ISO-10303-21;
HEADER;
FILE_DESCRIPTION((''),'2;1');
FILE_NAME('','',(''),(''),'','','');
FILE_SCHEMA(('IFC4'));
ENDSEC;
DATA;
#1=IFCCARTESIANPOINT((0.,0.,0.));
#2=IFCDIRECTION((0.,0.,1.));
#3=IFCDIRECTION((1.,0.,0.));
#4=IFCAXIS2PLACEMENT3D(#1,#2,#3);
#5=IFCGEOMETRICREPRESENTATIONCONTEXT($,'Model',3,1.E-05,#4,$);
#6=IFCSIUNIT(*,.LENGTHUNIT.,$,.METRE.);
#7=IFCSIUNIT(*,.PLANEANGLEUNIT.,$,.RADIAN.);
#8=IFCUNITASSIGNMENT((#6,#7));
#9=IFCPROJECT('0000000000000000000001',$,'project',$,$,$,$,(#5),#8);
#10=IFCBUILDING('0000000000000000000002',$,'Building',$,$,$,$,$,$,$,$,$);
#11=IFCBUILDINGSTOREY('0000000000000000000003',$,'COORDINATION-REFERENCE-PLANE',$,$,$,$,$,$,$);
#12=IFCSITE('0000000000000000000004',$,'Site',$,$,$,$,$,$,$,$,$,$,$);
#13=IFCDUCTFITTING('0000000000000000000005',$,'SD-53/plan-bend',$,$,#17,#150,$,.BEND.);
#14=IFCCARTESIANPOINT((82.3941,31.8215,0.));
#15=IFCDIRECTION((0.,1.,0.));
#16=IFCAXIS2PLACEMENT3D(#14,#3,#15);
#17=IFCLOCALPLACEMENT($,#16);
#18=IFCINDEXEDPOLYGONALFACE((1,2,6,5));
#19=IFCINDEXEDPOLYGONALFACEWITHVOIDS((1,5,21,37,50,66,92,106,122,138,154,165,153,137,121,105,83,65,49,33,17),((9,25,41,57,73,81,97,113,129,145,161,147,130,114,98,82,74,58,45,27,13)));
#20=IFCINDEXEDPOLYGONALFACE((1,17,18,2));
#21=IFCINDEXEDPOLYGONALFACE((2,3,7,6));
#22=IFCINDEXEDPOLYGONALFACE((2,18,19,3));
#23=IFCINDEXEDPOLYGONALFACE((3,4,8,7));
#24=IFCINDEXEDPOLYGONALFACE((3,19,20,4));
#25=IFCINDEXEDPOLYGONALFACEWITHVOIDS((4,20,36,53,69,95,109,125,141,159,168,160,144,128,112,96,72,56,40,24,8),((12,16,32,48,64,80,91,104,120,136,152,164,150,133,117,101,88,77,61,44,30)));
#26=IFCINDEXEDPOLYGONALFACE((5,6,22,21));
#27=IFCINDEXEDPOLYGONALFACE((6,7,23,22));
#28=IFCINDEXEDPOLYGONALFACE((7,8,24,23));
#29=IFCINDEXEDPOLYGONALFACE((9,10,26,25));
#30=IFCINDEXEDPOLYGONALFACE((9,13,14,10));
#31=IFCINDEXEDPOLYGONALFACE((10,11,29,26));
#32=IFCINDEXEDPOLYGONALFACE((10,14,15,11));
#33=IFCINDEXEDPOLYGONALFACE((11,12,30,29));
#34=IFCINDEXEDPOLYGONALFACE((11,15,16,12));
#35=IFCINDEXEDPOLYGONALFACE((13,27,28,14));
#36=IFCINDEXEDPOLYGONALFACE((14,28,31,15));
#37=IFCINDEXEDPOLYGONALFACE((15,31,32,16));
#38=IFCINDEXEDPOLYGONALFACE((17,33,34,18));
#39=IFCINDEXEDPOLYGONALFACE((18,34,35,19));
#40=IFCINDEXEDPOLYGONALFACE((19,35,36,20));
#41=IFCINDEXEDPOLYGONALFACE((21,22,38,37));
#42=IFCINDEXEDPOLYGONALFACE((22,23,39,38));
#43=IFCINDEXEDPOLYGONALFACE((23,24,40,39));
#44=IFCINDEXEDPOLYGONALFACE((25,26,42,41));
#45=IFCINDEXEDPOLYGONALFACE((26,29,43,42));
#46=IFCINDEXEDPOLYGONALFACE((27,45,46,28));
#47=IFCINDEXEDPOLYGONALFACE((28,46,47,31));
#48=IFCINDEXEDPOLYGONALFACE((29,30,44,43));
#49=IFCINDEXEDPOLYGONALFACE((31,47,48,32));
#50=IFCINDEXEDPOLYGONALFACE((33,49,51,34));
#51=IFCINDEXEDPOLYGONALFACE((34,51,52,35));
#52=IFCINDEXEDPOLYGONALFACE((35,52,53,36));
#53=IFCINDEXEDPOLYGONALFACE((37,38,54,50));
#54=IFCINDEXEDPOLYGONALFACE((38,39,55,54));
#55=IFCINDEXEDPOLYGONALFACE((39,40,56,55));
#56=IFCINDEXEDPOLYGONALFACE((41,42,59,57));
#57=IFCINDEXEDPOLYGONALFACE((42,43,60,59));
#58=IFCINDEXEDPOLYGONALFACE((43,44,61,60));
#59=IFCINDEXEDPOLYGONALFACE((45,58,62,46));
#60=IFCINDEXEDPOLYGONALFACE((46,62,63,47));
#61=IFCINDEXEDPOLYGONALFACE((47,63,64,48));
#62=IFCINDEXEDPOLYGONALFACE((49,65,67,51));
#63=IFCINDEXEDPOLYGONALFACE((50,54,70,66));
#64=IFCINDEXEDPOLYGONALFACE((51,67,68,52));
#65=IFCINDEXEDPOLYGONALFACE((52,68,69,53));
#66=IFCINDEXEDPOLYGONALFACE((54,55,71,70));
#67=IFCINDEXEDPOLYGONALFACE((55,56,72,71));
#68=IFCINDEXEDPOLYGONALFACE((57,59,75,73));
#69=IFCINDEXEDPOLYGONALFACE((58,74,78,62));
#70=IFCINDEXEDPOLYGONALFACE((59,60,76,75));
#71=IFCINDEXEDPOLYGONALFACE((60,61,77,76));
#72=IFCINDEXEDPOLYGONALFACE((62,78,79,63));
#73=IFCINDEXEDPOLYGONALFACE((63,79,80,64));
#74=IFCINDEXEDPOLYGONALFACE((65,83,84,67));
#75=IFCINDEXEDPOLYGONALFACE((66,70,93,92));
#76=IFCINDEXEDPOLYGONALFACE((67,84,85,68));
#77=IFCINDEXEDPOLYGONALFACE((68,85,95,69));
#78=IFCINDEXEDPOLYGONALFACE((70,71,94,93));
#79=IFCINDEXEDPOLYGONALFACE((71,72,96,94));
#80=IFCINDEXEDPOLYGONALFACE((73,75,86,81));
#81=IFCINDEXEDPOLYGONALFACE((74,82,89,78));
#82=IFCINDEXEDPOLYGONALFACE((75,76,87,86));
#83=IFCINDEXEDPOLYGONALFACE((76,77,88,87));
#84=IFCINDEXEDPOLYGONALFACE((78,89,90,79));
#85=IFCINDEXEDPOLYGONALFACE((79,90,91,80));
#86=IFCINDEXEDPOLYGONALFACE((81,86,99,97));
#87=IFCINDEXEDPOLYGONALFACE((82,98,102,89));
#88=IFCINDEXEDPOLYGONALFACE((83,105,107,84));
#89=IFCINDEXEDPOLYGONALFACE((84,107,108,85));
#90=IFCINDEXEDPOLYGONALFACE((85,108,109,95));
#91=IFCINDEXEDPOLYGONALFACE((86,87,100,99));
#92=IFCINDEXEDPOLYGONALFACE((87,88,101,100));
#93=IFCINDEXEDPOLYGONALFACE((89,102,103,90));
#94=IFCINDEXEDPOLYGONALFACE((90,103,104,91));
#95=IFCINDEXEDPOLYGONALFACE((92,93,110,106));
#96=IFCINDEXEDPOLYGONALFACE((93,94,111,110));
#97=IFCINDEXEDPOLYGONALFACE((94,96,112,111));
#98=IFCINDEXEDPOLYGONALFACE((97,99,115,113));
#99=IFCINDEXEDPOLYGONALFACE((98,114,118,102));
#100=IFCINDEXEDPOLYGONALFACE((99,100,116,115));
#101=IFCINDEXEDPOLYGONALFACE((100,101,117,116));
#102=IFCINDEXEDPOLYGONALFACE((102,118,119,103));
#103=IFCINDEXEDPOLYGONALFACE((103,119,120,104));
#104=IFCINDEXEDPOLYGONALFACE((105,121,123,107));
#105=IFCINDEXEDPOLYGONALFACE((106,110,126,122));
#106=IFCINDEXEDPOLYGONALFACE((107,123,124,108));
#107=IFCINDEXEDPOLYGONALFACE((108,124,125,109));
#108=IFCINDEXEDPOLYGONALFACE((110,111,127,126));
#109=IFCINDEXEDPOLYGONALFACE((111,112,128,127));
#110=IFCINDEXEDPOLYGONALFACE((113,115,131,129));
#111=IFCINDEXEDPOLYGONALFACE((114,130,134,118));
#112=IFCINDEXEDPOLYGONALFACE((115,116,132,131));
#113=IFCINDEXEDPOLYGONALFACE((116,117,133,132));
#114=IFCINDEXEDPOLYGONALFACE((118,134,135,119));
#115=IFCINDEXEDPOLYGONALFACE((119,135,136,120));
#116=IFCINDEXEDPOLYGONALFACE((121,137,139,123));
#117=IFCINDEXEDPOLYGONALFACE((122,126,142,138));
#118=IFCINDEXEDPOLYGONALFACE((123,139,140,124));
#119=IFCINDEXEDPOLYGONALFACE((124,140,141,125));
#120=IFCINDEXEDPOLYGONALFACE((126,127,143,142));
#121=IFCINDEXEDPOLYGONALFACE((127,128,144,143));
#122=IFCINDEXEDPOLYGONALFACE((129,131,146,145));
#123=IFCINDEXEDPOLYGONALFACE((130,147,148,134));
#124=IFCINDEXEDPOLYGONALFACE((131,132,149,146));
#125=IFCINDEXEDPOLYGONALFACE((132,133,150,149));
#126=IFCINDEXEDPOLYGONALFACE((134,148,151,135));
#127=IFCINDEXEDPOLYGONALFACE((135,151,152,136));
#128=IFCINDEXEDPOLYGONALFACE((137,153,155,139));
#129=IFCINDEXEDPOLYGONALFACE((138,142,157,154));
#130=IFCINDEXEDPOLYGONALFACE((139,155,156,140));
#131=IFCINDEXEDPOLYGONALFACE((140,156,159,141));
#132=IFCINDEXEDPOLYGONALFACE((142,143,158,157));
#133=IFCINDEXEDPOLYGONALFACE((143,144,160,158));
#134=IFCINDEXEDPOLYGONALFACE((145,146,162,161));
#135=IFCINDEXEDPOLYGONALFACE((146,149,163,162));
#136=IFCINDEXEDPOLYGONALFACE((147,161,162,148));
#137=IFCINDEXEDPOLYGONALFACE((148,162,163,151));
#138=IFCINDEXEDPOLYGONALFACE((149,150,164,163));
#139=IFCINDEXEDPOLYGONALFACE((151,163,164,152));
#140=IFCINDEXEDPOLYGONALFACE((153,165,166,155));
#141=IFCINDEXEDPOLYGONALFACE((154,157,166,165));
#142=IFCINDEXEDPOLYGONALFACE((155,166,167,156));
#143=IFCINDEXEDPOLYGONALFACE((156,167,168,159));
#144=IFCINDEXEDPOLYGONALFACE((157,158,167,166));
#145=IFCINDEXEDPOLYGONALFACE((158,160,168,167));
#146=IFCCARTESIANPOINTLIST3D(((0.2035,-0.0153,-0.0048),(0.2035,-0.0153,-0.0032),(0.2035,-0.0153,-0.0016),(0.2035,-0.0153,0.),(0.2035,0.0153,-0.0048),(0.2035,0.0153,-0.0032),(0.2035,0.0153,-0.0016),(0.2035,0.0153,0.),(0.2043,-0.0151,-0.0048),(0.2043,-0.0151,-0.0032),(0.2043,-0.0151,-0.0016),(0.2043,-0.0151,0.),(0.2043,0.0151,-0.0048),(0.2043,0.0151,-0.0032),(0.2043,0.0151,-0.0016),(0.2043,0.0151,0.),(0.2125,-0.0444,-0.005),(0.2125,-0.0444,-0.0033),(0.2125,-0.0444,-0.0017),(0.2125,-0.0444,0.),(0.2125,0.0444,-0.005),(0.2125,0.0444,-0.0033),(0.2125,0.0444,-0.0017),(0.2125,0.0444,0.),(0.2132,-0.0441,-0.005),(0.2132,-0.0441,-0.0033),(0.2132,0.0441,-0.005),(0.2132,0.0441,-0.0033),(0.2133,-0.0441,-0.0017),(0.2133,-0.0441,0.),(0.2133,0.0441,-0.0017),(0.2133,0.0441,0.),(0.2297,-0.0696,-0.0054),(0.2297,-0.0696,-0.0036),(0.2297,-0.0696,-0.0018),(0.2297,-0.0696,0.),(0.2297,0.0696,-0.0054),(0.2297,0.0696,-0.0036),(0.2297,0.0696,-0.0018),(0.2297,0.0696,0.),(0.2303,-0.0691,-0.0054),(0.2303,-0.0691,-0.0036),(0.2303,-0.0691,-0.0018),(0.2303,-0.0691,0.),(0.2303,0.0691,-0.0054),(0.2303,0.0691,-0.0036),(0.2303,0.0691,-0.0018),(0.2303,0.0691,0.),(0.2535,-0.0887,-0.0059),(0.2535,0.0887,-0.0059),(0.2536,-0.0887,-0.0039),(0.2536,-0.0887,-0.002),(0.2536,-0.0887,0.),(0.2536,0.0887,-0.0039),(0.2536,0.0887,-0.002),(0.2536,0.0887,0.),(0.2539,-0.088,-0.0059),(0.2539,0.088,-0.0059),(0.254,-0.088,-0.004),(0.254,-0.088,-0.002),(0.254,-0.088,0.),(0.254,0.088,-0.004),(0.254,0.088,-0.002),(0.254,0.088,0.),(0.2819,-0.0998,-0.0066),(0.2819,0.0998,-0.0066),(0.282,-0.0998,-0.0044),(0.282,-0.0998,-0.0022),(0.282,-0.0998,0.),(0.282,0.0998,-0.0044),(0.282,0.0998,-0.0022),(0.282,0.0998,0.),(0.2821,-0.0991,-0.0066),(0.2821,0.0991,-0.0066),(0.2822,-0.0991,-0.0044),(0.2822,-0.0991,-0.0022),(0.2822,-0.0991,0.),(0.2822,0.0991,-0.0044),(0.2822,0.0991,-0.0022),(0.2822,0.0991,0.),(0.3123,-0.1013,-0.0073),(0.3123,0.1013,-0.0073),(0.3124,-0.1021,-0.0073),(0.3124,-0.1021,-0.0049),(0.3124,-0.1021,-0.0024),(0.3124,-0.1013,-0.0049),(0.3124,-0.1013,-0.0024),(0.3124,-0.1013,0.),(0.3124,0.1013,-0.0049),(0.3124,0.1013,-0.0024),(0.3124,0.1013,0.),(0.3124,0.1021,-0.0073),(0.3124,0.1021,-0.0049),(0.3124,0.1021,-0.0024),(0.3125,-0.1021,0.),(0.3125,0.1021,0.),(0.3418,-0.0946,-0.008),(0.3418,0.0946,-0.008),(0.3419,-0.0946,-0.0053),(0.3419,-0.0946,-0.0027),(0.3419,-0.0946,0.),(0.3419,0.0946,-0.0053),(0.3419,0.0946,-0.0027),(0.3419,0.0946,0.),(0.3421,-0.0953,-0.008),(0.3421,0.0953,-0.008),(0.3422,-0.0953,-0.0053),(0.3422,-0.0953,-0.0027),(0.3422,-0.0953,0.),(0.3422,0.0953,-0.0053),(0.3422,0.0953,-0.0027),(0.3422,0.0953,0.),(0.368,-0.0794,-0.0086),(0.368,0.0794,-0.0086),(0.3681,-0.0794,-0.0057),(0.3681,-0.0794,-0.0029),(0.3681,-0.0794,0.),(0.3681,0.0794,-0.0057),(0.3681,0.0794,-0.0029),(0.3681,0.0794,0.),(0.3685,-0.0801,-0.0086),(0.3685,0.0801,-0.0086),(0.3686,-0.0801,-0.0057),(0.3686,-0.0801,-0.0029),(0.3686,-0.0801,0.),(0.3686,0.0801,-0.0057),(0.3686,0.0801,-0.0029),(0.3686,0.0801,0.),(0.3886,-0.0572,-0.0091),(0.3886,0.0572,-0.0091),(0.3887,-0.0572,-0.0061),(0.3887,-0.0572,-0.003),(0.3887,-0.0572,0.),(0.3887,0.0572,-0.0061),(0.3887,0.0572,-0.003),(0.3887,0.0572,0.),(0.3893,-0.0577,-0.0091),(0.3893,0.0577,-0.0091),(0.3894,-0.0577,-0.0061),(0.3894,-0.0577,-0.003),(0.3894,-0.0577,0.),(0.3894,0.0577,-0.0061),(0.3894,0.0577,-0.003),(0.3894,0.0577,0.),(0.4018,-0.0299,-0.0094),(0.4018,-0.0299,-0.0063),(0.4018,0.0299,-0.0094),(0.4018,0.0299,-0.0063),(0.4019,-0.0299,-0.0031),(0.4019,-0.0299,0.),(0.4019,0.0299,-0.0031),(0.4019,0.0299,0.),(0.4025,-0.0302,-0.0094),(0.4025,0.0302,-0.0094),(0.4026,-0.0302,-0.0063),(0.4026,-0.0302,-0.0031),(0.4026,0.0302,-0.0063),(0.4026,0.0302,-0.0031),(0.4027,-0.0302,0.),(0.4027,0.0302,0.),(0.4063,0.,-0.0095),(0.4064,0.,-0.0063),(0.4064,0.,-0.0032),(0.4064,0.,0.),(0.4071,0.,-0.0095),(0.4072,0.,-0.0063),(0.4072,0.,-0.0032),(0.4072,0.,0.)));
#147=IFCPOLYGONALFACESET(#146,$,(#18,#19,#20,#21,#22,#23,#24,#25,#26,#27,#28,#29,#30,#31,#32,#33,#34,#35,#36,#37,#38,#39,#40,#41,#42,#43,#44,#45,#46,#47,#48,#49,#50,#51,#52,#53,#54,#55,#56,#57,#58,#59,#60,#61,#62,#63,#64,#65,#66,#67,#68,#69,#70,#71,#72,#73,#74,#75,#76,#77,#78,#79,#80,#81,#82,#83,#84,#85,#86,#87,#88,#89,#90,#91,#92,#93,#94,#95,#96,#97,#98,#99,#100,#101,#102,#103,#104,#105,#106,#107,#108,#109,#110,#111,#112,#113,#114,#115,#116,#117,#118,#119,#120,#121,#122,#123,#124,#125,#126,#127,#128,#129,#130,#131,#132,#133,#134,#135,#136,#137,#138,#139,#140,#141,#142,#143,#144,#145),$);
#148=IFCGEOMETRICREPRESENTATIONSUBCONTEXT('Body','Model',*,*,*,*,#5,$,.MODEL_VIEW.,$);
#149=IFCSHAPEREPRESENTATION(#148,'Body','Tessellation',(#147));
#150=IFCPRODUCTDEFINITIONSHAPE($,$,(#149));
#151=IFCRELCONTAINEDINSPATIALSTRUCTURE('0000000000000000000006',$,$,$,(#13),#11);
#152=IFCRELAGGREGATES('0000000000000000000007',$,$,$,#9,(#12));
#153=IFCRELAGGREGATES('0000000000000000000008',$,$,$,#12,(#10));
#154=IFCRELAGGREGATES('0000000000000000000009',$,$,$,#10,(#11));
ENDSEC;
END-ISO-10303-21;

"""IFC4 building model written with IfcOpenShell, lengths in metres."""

from ifc_helpers import new_model, entity, si_unit, frame, origin_with_axes, place, context, subcontext, project, spatial, element, save


model = new_model("IFC4")

# Units and contexts
model_context = context("Model", 3, precision=1e-05, world=origin_with_axes())
body_context_1 = subcontext(model_context, "Body", "Model", "MODEL_VIEW")
ifc_project = project(units=[si_unit("LENGTHUNIT", "METRE"), si_unit("PLANEANGLEUNIT", "RADIAN")], contexts=[model_context])

# Site, building, storey
site = spatial("IfcSite", under=ifc_project, Name="Site")
building = spatial("IfcBuilding", under=site, Name="Building")
storey = spatial("IfcBuildingStorey", under=building, Name="COORDINATION-REFERENCE-PLANE")

# Duct fitting
duct_fitting_1_placement = place(None, frame((82.3941, 31.8215, 0.0), z_axis=(1.0, 0.0, 0.0), x_axis=(0.0, 1.0, 0.0)))
element("IfcDuctFitting", 1, at=duct_fitting_1_placement, inside=storey, Name="SD-53/plan-bend", PredefinedType="BEND", context=body_context_1, shape_type="SweptSolid", body=[
    entity("IfcRevolvedAreaSolid", entity("IfcCircleHollowProfileDef", "AREA", None, entity("IfcAxis2Placement2D", entity("IfcCartesianPoint", [0.3048, 0.0])), 0.1024, 0.0008), entity("IfcAxis2Placement3D", entity("IfcCartesianPoint", [0.0, 0.0, 0.0]), entity("IfcDirection", [0.0, 0.0, 1.0]), entity("IfcDirection", [1.0, 0.0, 0.0])), entity("IfcAxis1Placement", entity("IfcCartesianPoint", [0.0, 0.0, 0.0]), entity("IfcDirection", [0.0, 1.0, 0.0])), 0.023363),
])

save(model, "model.ifc")
